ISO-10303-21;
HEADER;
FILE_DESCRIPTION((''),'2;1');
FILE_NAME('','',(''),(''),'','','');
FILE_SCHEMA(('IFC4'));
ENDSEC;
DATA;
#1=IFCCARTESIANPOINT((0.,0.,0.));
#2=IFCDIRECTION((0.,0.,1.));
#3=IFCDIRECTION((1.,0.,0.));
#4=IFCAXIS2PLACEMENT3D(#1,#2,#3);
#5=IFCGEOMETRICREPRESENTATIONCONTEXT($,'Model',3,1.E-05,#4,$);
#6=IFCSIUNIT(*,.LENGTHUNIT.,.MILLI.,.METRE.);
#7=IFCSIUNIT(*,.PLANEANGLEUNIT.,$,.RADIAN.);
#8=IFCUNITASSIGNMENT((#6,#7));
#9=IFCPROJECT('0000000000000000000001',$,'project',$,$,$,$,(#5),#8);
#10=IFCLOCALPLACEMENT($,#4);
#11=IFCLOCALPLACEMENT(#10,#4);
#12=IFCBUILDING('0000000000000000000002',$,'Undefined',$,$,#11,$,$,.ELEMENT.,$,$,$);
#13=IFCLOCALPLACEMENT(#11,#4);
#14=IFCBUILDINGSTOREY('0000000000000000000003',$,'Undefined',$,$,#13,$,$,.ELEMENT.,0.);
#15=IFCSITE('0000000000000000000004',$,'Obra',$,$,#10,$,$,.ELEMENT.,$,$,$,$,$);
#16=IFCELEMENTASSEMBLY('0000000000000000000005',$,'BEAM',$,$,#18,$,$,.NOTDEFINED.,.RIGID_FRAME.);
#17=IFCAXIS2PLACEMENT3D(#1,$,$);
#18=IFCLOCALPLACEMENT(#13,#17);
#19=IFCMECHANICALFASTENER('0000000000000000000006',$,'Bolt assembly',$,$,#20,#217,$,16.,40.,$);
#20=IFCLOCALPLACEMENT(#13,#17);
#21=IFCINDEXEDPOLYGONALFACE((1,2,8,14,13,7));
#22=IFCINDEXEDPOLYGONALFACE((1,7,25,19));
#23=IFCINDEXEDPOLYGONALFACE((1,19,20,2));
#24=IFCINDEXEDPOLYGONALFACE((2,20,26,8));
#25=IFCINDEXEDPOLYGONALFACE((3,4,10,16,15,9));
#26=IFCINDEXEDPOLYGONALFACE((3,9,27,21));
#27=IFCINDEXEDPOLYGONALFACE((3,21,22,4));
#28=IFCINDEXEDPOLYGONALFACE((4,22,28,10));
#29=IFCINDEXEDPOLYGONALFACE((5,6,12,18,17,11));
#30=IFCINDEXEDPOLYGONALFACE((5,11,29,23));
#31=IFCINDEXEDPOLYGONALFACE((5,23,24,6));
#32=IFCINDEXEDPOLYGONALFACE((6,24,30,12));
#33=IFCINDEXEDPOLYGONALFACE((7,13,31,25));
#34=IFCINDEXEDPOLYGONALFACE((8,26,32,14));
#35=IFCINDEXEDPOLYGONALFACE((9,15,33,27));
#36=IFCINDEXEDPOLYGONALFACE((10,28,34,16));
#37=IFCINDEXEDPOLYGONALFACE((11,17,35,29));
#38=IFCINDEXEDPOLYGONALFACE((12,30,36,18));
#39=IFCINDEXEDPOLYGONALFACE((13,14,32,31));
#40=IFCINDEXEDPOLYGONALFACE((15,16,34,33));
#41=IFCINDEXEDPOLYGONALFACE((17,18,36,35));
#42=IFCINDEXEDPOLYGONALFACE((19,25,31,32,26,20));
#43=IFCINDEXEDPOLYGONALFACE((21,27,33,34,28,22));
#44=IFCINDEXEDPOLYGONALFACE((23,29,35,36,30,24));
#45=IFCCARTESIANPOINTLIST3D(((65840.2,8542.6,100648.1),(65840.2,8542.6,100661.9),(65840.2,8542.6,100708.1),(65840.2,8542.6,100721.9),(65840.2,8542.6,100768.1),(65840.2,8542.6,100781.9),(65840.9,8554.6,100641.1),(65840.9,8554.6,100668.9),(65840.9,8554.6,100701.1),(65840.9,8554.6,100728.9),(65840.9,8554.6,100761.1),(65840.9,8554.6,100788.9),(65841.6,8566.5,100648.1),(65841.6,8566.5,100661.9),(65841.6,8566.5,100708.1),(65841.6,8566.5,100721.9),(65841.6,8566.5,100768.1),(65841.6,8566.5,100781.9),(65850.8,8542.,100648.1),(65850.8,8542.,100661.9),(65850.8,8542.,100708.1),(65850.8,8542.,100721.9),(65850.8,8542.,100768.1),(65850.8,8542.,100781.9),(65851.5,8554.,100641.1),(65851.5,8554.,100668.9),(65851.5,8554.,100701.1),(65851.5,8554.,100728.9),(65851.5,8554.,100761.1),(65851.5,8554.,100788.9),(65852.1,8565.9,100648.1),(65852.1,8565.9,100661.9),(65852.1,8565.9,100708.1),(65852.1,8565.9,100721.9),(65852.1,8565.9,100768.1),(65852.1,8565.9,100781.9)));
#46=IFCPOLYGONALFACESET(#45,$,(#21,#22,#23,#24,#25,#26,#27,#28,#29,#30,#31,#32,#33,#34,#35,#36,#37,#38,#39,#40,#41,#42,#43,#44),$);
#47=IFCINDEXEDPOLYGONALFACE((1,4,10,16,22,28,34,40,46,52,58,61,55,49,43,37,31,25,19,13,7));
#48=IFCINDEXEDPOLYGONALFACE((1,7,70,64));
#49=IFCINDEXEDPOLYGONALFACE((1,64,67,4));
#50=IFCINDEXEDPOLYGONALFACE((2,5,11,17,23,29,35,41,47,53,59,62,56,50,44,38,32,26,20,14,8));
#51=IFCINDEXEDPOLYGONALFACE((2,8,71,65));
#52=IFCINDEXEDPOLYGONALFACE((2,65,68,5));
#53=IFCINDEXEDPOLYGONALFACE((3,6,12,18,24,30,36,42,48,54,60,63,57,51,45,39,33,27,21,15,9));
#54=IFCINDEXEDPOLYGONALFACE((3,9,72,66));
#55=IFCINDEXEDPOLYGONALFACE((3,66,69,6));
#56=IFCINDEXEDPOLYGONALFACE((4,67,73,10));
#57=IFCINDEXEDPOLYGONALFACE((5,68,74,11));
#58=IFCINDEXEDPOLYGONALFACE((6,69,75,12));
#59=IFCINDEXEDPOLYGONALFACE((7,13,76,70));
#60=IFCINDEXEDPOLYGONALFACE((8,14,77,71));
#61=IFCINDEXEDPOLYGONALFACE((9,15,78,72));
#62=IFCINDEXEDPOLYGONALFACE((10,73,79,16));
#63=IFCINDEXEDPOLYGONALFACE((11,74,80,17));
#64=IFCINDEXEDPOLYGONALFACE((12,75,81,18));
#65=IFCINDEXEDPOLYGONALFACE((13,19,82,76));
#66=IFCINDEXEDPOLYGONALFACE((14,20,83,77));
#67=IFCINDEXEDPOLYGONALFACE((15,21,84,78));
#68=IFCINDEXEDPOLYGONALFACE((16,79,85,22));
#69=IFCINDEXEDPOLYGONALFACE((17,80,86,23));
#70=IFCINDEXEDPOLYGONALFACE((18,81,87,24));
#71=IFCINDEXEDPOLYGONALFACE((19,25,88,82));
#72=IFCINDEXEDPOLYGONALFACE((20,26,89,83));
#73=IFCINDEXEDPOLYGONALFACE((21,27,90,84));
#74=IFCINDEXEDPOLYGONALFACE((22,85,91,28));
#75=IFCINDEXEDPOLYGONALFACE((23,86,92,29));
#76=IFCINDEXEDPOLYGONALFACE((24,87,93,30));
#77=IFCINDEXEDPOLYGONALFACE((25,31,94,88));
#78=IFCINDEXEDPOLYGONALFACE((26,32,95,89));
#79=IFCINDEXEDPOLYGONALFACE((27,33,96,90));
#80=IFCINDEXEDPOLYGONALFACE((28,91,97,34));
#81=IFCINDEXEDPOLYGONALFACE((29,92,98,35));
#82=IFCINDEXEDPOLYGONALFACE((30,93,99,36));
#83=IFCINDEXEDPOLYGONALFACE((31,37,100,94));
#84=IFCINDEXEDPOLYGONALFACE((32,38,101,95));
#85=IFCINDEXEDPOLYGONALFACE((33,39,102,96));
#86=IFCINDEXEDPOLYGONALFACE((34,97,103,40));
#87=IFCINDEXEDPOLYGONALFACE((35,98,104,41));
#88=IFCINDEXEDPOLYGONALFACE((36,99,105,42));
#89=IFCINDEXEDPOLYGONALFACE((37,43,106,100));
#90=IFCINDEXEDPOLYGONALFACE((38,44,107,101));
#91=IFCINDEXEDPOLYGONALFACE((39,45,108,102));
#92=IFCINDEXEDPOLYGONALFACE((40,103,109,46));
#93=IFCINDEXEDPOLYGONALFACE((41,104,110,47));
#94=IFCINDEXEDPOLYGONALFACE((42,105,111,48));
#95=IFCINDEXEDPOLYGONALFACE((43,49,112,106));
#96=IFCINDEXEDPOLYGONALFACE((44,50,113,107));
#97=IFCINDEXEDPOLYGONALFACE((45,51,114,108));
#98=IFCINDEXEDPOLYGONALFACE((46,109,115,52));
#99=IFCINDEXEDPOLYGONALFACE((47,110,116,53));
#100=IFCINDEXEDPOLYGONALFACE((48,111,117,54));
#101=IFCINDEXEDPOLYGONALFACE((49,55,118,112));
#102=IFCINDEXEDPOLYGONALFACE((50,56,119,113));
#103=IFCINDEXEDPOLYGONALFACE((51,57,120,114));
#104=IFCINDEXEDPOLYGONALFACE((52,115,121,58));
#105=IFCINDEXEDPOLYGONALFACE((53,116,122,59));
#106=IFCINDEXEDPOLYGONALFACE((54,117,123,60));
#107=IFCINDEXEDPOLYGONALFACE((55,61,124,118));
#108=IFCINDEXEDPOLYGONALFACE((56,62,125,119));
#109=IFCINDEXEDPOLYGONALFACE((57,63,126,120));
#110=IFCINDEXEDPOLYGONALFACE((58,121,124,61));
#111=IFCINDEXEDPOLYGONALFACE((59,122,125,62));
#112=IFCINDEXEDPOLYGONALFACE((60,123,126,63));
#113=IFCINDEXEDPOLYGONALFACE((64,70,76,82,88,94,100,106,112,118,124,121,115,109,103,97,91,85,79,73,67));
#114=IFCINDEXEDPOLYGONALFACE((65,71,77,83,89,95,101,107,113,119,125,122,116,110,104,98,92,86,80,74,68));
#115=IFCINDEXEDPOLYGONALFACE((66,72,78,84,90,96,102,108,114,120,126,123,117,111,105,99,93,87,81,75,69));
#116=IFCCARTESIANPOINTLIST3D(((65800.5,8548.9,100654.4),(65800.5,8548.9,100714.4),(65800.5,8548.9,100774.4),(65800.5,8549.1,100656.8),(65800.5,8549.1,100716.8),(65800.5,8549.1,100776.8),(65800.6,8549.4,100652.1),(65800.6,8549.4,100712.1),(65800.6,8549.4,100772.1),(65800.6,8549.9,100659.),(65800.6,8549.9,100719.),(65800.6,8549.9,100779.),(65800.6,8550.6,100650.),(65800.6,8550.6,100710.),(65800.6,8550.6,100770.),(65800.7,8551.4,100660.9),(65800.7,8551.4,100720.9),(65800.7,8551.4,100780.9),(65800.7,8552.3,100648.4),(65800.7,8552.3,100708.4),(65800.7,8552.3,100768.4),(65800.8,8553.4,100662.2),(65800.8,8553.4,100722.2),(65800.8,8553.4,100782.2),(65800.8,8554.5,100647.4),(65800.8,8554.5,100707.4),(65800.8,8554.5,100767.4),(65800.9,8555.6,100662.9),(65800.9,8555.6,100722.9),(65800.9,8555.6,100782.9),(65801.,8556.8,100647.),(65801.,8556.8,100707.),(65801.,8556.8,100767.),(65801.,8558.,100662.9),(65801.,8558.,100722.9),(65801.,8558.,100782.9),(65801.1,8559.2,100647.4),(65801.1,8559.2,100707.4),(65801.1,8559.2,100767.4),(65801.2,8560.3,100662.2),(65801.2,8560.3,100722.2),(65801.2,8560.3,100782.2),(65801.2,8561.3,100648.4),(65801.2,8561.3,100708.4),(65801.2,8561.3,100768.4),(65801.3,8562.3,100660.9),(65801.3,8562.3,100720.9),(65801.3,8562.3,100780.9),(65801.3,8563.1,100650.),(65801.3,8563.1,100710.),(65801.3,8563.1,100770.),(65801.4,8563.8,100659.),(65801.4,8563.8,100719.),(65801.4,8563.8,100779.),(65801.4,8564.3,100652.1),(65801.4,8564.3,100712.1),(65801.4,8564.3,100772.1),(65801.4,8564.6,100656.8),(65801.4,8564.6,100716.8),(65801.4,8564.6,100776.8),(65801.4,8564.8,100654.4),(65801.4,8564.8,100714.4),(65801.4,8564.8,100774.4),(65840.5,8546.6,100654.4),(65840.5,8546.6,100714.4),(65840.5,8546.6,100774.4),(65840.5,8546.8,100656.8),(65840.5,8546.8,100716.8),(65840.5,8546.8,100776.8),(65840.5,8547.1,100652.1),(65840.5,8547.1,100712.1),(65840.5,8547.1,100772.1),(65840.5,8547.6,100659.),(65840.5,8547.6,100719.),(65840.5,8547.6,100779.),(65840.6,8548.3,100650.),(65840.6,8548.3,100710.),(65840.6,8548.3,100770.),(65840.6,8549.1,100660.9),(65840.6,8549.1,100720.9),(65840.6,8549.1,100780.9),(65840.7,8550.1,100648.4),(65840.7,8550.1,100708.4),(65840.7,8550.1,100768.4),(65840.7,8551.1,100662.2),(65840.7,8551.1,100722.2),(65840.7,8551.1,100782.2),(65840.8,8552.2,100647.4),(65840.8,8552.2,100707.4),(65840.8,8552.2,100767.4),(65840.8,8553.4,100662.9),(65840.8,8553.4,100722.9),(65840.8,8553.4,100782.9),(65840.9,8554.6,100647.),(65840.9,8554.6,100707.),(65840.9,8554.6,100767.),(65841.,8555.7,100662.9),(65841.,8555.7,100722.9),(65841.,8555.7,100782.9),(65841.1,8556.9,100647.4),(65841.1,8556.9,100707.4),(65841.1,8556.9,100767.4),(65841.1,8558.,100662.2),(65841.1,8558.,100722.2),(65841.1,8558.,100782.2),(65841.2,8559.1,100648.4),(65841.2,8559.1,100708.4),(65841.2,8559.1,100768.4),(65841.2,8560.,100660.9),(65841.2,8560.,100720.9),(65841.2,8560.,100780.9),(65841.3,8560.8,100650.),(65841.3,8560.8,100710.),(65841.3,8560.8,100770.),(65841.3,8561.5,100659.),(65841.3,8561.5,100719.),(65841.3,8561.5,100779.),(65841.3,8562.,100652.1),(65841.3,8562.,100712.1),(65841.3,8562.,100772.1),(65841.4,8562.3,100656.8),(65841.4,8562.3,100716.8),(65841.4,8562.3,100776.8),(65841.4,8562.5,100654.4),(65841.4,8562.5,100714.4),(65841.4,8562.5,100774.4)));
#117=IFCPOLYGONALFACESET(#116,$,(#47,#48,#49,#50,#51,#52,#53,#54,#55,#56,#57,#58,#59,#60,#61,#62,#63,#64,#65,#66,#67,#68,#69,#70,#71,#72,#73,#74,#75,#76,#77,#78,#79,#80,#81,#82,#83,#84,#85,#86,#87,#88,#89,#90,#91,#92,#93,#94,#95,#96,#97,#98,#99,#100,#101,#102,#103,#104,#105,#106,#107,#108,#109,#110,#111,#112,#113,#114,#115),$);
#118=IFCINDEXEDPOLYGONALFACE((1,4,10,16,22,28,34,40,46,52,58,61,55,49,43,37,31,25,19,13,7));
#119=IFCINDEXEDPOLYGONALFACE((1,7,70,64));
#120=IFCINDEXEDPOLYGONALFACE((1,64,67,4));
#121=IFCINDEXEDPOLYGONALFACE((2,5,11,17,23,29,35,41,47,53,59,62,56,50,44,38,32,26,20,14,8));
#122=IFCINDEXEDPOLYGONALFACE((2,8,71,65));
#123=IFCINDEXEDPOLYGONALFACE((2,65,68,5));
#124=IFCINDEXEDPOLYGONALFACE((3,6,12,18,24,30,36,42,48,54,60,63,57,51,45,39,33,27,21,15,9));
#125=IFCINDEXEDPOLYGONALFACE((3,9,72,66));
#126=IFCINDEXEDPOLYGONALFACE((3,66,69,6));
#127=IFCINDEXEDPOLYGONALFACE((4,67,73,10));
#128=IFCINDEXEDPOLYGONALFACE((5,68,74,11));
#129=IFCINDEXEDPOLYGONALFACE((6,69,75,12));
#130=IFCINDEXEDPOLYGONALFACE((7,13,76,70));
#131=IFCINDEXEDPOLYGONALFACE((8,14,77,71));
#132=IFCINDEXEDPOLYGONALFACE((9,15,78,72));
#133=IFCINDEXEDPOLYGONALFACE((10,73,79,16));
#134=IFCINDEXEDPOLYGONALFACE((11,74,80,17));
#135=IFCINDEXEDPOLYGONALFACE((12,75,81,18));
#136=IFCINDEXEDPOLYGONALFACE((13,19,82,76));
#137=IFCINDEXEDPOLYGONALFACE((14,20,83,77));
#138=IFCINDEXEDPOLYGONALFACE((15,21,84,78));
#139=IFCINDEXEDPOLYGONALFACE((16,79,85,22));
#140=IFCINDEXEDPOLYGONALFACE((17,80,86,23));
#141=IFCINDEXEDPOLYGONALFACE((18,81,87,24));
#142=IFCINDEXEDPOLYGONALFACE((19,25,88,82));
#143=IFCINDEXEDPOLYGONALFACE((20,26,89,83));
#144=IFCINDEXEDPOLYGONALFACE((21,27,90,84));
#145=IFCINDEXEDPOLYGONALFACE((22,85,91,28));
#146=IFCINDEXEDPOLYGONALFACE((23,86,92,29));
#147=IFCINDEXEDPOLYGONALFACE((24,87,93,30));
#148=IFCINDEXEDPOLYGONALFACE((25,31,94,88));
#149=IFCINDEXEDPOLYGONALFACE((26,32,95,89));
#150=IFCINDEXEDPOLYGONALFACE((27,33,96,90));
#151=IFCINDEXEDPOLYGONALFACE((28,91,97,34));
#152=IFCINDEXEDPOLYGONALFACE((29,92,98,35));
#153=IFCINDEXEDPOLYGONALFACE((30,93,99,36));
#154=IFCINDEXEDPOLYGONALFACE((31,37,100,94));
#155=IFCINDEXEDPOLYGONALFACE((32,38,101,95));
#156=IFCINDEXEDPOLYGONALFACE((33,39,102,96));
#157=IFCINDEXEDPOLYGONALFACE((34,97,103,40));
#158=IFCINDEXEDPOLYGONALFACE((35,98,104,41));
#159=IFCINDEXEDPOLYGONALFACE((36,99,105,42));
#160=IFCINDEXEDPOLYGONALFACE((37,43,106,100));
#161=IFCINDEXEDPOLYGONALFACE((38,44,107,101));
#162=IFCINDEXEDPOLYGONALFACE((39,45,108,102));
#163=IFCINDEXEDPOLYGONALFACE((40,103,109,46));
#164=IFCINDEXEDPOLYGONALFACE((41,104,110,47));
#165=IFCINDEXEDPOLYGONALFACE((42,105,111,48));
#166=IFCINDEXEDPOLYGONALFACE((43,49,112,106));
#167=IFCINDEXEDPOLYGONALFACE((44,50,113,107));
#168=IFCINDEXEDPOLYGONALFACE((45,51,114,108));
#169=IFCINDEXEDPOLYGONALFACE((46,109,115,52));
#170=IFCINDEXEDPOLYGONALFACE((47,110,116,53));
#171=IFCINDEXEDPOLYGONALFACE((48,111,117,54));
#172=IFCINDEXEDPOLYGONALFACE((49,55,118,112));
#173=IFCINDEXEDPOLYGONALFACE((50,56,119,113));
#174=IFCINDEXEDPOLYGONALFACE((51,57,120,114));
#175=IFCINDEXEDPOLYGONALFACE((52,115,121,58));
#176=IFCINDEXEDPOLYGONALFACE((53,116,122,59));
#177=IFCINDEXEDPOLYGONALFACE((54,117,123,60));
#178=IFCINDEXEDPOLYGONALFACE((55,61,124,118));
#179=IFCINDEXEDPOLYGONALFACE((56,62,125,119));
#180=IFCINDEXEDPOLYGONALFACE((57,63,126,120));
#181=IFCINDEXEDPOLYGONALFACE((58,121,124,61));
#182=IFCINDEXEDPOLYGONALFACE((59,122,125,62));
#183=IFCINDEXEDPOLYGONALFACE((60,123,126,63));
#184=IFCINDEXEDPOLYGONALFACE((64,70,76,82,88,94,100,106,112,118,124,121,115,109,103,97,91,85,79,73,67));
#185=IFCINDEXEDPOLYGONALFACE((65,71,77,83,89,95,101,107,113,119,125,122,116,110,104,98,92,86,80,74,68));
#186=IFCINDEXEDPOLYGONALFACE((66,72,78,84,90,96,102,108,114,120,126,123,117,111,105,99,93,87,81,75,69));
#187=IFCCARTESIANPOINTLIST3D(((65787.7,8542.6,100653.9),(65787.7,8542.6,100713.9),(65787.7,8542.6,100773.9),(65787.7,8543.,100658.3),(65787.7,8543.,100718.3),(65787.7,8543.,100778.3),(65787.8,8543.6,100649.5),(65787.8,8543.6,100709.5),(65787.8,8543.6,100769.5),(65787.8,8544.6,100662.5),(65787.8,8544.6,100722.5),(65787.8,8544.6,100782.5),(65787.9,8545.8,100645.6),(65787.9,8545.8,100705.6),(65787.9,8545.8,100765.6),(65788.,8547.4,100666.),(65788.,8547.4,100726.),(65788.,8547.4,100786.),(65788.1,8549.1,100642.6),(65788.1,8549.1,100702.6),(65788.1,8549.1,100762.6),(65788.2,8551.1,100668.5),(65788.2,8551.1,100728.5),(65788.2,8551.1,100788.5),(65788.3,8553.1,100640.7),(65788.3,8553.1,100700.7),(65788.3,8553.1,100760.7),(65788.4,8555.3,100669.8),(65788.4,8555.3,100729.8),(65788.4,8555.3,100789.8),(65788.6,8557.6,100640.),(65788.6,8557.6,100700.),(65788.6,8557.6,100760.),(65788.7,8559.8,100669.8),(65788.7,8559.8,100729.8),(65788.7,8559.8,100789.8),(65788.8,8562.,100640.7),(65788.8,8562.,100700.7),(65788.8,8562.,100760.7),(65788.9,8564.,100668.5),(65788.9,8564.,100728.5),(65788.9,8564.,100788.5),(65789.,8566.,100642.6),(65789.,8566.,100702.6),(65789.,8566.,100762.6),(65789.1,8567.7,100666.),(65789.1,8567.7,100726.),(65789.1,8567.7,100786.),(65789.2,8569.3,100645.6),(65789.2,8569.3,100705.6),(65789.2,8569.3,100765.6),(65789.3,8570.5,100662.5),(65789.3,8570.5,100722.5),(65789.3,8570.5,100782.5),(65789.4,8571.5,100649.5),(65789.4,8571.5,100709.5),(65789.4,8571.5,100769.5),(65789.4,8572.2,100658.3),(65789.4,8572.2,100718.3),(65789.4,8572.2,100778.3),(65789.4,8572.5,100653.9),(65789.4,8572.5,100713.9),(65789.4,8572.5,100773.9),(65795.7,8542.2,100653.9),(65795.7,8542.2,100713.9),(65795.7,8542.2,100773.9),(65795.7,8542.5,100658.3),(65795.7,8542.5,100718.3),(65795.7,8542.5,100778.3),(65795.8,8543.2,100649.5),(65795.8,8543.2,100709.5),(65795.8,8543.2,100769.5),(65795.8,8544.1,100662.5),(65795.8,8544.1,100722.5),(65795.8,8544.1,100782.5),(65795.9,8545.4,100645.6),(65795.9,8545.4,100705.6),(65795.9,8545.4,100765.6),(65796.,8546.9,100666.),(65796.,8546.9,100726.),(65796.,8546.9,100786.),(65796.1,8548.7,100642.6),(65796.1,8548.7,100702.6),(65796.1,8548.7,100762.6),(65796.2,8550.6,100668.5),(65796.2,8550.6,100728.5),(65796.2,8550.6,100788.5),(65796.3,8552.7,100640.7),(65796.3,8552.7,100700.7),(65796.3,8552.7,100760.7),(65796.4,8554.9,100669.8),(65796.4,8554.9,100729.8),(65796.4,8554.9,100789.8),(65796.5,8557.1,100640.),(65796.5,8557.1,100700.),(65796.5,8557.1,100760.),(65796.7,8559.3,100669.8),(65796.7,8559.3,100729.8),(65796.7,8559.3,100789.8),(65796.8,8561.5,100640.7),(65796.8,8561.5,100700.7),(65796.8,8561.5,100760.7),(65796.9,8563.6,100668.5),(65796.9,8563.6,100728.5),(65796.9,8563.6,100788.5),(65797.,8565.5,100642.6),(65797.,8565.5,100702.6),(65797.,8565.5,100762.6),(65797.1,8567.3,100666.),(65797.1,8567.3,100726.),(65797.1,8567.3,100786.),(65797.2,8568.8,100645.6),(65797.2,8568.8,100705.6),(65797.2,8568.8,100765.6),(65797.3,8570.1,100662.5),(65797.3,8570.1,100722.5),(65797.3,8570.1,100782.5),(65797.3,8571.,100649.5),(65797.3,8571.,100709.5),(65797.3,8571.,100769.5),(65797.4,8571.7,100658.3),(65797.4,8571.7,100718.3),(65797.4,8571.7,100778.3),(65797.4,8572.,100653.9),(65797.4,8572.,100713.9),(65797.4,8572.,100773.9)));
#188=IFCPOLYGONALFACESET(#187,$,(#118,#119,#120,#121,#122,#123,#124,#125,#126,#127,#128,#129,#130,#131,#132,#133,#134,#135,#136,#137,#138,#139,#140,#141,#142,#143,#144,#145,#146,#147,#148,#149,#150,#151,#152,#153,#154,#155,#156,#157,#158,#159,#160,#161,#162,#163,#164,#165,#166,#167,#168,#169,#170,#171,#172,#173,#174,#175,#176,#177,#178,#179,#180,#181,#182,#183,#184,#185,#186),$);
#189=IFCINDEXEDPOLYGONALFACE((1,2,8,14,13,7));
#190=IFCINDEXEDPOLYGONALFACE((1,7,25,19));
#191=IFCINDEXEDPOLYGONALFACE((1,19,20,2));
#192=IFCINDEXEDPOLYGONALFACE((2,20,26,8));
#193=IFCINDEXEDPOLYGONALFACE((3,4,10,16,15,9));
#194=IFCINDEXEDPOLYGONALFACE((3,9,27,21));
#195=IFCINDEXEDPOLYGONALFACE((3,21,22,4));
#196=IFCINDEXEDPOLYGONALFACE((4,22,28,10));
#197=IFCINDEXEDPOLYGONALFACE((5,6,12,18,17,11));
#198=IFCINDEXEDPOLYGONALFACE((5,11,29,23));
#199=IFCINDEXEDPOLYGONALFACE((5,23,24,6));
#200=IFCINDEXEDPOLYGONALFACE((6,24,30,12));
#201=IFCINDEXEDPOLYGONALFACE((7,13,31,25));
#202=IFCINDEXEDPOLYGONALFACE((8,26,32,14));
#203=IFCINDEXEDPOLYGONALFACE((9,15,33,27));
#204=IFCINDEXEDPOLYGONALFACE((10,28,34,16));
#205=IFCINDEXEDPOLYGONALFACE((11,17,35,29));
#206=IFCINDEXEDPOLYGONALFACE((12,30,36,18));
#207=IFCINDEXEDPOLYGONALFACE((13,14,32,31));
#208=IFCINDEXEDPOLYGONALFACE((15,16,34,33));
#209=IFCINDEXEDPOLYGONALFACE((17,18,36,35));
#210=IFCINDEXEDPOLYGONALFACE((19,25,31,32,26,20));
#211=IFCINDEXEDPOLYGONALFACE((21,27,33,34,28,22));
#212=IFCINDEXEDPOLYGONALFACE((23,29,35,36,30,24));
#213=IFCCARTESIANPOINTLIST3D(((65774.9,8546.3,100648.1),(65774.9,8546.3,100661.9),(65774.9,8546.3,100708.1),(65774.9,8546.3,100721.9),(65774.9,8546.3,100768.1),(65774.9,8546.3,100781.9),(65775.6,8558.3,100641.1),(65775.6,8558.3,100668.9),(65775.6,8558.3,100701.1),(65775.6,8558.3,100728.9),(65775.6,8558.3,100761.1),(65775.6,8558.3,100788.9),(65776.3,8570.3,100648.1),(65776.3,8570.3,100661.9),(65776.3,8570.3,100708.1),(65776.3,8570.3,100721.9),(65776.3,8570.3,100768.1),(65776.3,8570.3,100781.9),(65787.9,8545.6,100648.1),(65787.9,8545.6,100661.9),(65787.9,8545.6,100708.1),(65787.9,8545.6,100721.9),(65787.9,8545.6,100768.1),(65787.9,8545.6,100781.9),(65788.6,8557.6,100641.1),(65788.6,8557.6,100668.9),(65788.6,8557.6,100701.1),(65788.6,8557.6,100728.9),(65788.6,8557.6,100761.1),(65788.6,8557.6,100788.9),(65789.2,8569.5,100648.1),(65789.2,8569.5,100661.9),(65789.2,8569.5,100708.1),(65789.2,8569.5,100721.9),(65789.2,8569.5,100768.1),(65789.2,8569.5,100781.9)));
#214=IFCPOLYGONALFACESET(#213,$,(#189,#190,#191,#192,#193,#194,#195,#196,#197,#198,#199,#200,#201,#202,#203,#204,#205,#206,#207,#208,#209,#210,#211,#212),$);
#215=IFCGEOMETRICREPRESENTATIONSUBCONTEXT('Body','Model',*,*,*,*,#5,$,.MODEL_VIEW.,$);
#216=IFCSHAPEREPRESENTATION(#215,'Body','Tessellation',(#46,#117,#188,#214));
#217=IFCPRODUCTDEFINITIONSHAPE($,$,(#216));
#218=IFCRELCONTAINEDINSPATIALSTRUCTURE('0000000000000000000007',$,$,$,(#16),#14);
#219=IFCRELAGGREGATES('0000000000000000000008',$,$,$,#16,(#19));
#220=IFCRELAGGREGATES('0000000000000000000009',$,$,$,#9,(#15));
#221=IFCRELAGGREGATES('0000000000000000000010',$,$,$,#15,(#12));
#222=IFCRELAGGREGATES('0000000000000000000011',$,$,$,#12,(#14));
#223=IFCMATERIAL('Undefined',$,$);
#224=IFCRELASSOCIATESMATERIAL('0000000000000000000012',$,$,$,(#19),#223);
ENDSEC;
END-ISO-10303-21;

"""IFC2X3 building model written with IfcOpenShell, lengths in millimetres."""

from ifc_helpers import new_model, si_unit, frame, origin_with_axes, origin_2d_with_axis, place, context, subcontext, project, spatial, polyline, circle, outline, extrude, source, transform, mapped, material, element, aggregate, save


model = new_model("IFC2X3")

# Units and contexts
model_context = context("Model", 3, precision=1e-05, world=origin_with_axes())
body_context = subcontext(model_context, "Body", "Model", "MODEL_VIEW")
ifc_project = project(units=[si_unit("LENGTHUNIT", "METRE", prefix="MILLI"), si_unit("PLANEANGLEUNIT", "RADIAN")], contexts=[model_context])

# Site, building, storey
site_placement = place(None, origin_with_axes())
site = spatial("IfcSite", under=ifc_project, at=site_placement, Name="Obra", CompositionType="ELEMENT")
building_placement = place(site_placement, origin_with_axes())
building = spatial("IfcBuilding", under=site, at=building_placement, Name="Undefined", CompositionType="ELEMENT")
storey_placement = place(building_placement, origin_with_axes())
storey = spatial("IfcBuildingStorey", under=building, at=storey_placement, Name="Undefined", CompositionType="ELEMENT", Elevation=0.0)

# Shared definitions
ifc_material_1 = material(Name="Undefined")

# Shared definitions
shared_shape_1 = source(origin_with_axes(), body_context, "Body", "SweptSolid", [
    extrude(outline(polyline([(13.9, 0.0), (6.9, 12.0), (-6.9, 12.0), (-13.9, 0.0), (-6.9, -12.0), (6.9, -12.0), (13.9, 0.0)])), frame((0.0, -19.7, 0.0), z_axis=(0.0, 1.0, 0.0), x_axis=(1.0, 0.0, 0.0)), (0.0, 0.0, 1.0), 10.6),
    extrude(circle(Radius=8.0, at=origin_2d_with_axis()), frame((0.0, -9.1, 0.0), z_axis=(0.0, 1.0, 0.0), x_axis=(1.0, 0.0, 0.0)), (0.0, 0.0, 1.0), 40.0),
    extrude(circle(Radius=15.0, at=origin_2d_with_axis()), frame((0.0, 35.3, 0.0), z_axis=(0.0, 1.0, 0.0), x_axis=(1.0, 0.0, 0.0)), (0.0, 0.0, 1.0), 8.0),
    extrude(outline(polyline([(13.9, 0.0), (6.9, 12.0), (-6.9, 12.0), (-13.9, 0.0), (-6.9, -12.0), (6.9, -12.0), (13.9, 0.0)])), frame((0.0, 43.3, 0.0), z_axis=(0.0, 1.0, 0.0), x_axis=(1.0, 0.0, 0.0)), (0.0, 0.0, 1.0), 13.0),
])

# Element assembly, mechanical fastener
assembly_1_placement = place(storey_placement, origin_with_axes())
assembly_1 = element("IfcElementAssembly", 1, at=assembly_1_placement, inside=storey, Name="BEAM", AssemblyPlace="NOTDEFINED", PredefinedType="RIGID_FRAME")
mechanical_fastener_1_placement = place(assembly_1_placement, frame((65829.0, 8505.2, 100835.0), z_axis=(0.05711, 0.998368, 0.0), x_axis=(0.0, 0.0, -1.0)))
mechanical_fastener_1 = element("IfcMechanicalFastener", 2, at=mechanical_fastener_1_placement, material=ifc_material_1, Name="Bolt assembly", NominalDiameter=16.0, NominalLength=40.0, context=body_context, shape_type="MappedRepresentation", body=[
    mapped(shared_shape_1, transform((60.0, 0.0, 50.0))),
    mapped(shared_shape_1, transform((120.0, 0.0, 50.0))),
    mapped(shared_shape_1, transform((180.0, 0.0, 50.0))),
])
aggregate(assembly_1, [mechanical_fastener_1])

save(model, "model.ifc")
